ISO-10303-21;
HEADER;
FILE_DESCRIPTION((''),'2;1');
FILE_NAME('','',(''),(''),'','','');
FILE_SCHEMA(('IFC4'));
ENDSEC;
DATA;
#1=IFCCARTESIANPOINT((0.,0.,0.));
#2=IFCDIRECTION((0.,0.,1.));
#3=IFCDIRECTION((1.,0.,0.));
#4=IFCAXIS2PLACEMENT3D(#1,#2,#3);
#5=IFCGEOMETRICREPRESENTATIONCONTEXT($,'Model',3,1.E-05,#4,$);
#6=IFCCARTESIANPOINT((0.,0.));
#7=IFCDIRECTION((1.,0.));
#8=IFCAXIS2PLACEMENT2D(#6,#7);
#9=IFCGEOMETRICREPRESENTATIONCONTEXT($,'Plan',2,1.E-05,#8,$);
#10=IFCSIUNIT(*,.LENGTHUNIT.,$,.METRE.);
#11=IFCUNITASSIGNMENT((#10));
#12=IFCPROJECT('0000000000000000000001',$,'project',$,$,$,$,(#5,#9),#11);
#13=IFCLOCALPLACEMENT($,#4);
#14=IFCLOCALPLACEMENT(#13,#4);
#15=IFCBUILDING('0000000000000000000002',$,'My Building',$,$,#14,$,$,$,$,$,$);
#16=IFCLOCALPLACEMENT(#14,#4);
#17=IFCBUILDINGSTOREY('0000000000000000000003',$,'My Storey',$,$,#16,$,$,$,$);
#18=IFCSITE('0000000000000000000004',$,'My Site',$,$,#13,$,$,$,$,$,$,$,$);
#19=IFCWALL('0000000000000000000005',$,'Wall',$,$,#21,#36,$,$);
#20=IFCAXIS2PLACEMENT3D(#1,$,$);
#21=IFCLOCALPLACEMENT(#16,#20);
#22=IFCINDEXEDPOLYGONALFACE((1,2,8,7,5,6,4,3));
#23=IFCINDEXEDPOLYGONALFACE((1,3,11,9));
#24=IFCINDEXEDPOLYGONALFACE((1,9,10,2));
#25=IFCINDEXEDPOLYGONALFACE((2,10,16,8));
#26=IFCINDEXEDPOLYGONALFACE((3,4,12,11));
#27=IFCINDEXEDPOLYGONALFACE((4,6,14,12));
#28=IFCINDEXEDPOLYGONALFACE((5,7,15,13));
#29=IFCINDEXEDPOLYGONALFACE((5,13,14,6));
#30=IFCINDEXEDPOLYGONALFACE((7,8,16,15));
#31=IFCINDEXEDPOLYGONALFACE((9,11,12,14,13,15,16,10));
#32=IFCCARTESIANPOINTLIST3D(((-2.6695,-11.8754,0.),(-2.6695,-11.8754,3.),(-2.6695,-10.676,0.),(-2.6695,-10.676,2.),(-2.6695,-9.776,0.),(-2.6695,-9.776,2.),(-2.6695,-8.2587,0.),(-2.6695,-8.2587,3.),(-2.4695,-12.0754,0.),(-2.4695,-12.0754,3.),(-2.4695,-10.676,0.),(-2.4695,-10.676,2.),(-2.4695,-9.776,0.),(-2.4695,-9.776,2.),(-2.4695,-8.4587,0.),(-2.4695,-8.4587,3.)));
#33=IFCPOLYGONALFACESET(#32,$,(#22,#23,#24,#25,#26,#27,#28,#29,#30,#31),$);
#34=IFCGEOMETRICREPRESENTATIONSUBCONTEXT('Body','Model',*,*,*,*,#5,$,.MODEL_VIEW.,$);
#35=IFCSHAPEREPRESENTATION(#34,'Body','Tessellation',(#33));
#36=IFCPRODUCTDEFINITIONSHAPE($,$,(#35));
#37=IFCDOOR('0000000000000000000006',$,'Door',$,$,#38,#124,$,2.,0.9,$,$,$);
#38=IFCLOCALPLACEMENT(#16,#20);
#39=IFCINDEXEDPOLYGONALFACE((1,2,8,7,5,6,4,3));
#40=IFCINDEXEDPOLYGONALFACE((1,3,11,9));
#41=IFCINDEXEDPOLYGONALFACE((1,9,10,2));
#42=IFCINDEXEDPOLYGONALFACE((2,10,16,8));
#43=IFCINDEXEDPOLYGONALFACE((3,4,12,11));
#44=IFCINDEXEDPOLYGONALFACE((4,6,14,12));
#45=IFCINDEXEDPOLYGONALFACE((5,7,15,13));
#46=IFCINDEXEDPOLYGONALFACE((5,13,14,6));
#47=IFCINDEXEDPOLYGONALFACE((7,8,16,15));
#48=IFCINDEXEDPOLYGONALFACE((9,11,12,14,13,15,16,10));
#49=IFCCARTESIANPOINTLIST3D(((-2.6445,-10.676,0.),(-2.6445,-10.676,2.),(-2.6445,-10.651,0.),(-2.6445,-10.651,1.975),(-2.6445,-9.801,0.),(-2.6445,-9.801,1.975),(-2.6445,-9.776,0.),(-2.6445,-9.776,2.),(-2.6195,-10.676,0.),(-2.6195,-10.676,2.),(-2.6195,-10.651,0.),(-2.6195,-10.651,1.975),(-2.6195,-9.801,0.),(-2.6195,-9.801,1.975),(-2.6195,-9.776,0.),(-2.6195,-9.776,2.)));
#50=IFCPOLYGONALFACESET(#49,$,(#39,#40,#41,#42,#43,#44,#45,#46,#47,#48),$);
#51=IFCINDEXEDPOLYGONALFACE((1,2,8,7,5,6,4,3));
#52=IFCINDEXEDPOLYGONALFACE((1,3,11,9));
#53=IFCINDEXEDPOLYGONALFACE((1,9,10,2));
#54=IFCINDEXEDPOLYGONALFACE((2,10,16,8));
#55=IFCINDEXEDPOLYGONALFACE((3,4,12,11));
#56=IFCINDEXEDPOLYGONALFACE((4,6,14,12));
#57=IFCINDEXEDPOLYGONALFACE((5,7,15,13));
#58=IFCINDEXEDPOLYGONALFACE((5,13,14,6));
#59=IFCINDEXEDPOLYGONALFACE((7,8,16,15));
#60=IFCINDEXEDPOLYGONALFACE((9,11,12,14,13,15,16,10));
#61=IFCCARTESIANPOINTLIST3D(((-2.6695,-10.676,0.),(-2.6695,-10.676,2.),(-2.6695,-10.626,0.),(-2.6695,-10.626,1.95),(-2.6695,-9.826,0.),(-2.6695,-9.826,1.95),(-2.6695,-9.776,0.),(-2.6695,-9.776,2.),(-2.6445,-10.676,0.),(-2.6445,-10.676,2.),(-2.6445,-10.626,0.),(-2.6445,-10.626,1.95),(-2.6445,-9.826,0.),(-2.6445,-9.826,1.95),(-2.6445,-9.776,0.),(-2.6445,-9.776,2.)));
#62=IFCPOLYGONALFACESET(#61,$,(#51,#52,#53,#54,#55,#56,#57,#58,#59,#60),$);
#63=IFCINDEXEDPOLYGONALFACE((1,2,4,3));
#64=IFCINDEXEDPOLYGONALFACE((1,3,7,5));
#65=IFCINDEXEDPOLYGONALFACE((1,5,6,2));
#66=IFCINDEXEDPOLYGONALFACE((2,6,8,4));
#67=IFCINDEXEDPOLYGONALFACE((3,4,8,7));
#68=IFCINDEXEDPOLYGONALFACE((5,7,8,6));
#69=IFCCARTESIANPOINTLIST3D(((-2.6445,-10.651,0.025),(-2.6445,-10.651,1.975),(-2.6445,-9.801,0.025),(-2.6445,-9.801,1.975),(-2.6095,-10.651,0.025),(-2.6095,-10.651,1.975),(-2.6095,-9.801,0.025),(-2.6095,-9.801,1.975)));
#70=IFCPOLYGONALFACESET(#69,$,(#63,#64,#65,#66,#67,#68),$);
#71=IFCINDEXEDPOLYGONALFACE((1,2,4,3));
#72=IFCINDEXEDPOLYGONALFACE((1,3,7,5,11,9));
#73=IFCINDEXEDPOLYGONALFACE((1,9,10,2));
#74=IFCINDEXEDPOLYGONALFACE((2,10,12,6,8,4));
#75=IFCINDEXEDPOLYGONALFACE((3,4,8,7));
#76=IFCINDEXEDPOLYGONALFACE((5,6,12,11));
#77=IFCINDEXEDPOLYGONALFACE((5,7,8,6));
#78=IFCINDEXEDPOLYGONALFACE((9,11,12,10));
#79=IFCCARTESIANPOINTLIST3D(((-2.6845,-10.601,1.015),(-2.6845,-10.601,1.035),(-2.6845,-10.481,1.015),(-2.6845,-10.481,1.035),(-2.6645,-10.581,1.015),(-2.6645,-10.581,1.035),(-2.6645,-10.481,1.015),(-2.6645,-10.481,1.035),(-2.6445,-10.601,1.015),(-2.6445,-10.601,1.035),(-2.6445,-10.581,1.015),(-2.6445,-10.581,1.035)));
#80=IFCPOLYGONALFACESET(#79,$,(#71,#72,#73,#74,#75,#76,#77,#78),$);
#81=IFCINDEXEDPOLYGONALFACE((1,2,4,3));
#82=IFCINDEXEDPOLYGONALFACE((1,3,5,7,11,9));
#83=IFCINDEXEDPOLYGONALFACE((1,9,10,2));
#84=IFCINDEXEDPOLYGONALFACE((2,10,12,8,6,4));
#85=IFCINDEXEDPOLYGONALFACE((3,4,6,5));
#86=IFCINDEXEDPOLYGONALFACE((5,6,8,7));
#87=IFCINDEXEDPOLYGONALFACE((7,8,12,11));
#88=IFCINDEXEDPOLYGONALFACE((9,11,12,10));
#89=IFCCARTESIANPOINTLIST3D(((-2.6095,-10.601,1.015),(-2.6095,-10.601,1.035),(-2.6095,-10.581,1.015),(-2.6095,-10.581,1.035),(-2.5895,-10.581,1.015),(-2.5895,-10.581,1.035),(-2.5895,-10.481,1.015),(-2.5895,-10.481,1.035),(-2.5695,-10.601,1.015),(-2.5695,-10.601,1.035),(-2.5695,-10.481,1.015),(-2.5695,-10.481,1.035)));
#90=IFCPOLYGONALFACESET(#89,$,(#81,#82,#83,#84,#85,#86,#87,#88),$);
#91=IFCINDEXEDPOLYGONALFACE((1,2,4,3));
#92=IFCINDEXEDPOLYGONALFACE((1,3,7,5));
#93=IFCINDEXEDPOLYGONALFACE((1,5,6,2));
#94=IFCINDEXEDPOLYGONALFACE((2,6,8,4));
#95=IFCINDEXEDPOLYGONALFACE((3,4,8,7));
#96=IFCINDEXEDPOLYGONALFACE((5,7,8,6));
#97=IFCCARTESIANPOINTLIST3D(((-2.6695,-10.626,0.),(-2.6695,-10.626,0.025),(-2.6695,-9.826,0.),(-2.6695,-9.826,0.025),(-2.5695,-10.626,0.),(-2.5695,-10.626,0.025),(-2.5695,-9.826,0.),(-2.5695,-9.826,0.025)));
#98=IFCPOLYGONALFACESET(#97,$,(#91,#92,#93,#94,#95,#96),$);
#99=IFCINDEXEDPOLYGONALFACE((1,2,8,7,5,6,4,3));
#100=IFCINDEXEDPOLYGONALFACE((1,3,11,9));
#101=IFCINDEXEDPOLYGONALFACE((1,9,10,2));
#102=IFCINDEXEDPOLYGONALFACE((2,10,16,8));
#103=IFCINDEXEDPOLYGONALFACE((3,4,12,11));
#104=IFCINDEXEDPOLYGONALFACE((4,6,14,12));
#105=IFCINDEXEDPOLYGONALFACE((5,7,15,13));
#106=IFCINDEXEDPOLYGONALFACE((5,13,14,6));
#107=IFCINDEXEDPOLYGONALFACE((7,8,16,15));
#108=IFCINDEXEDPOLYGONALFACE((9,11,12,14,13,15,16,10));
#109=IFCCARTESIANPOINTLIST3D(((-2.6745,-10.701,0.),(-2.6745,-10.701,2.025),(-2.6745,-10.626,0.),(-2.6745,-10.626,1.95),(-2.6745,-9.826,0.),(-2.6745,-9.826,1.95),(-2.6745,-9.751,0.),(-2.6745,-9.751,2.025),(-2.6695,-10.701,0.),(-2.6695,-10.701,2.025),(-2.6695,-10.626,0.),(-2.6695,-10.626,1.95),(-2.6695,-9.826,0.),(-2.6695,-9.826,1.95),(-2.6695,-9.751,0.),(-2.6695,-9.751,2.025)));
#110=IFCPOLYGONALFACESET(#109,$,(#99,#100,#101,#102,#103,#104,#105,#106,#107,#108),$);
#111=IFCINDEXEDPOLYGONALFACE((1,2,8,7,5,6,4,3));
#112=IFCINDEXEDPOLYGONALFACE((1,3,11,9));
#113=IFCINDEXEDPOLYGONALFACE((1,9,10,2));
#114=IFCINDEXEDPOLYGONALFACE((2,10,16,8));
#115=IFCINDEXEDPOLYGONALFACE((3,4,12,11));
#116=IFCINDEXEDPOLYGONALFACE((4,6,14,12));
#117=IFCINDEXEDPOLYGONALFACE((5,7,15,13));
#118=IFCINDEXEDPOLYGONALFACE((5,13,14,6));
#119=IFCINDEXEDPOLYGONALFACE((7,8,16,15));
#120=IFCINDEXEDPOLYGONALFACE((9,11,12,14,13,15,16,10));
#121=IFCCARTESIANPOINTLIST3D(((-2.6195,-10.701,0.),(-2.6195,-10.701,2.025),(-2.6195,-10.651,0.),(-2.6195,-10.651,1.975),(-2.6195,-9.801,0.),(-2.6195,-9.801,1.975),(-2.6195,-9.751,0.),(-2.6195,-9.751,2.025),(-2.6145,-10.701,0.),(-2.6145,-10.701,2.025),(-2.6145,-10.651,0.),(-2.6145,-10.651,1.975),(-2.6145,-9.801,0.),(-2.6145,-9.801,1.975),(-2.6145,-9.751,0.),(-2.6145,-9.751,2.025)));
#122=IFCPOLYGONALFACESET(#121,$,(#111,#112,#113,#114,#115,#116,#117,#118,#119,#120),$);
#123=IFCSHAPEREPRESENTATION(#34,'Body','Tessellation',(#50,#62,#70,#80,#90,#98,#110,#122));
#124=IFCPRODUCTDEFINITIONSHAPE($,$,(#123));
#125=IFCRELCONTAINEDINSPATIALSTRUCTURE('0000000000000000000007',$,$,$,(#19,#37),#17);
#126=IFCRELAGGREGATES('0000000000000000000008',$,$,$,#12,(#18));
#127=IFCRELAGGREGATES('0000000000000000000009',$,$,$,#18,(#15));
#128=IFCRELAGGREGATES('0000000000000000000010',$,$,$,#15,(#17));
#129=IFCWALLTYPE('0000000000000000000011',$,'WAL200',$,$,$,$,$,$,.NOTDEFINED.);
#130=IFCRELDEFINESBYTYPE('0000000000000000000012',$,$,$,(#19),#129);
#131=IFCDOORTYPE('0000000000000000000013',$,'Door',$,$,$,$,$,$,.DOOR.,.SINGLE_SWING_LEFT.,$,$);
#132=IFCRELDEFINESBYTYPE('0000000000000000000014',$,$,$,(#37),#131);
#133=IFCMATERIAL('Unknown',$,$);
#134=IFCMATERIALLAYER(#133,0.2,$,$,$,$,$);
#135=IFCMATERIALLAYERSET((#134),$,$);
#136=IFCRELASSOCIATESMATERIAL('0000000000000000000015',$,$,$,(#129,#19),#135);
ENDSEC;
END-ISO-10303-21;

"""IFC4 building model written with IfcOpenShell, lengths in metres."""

from ifc_helpers import new_model, entity, si_unit, frame, origin_with_axes, origin_2d_with_axis, place, context, subcontext, project, spatial, line, indexed_curve, outline, extrude, shape, source, transform, mapped, material, layer, layer_set, layer_usage, type_object, type_shapes, element, fill, save


model = new_model("IFC4")

# Units and contexts
model_context = context("Model", 3, precision=1e-05, world=origin_with_axes())
plan_context = context("Plan", 2, precision=1e-05, world=origin_2d_with_axis())
body_context_1 = subcontext(model_context, "Body", "Model", "MODEL_VIEW")
body_context_2 = subcontext(plan_context, "Body", "Plan", "PLAN_VIEW")
ifc_project = project(units=[si_unit("LENGTHUNIT", "METRE")], contexts=[model_context, plan_context])

# Site, building, storey
site_placement = place(None, origin_with_axes())
site = spatial("IfcSite", under=ifc_project, at=site_placement, Name="My Site")
building_placement = place(site_placement, origin_with_axes())
building = spatial("IfcBuilding", under=site, at=building_placement, Name="My Building")
storey_placement = place(building_placement, origin_with_axes())
storey = spatial("IfcBuildingStorey", under=building, at=storey_placement, Name="My Storey")

# Shared definitions
ifc_material = material(Name="Unknown")

# Shared definitions
ifc_layer_1 = layer(ifc_material, 0.2)
ifc_layer_set_1 = layer_set([ifc_layer_1])
wall_type_1 = type_object("IfcWallType", Name="WAL200", PredefinedType="NOTDEFINED", material=ifc_layer_set_1)

# Wall, opening, door
ifc_layer_usage_1 = layer_usage(ifc_layer_set_1, "AXIS2", "POSITIVE", 0.0)
wall_1_placement = place(storey_placement, frame((-2.4695, -12.0754, 0.0), z_axis=(0.0, 0.0, 1.0), x_axis=(0.0, 1.0, 0.0)))
wall_1 = element("IfcWall", 1, at=wall_1_placement, inside=storey, type_object=wall_type_1, material=ifc_layer_usage_1, Name="Wall", context=body_context_1, shape_type="SweptSolid", body=[
    extrude(outline(indexed_curve([(0.0, 0.0), (0.2, 0.2), (3.8168, 0.2), (3.6168, 0.0)], segments=[line(1, 2, 3, 4, 1)])), origin_with_axes(), (0.0, 0.0, 1.0), 3.0),
])
shared_shape_1 = source(origin_with_axes(), body_context_1, "Body", "SweptSolid", [
    extrude(outline(indexed_curve([(0.0, 0.0), (0.9, 0.0), (0.9, 2.0), (0.0, 2.0)], segments=[line(1, 2, 3, 4, 1)])), frame((0.0, -0.6, 0.0), z_axis=(0.0, -1.0, 0.0), x_axis=(1.0, 0.0, 0.0)), (0.0, 0.0, -1.0), 1.2),
])
opening_1_placement = place(wall_1_placement, frame((2.2995, 0.2, 0.0), z_axis=(0.0, 0.0, 1.0), x_axis=(-1.0, 0.0, 0.0)))
opening_1 = element("IfcOpeningElement", 2, at=opening_1_placement, cuts=wall_1, PredefinedType="OPENING", context=body_context_1, shape_type="MappedRepresentation", body=[
    mapped(shared_shape_1, transform((0.0, 0.0, 0.0), x_axis=(1.0, 0.0, 0.0), y_axis=(0.0, 1.0, 0.0), z_axis=(0.0, 0.0, 1.0), scale=1.0)),
])
door_type = type_object("IfcDoorType", Name="Door", OperationType="SINGLE_SWING_LEFT", PredefinedType="DOOR")
shared_shape_2 = source(origin_with_axes(), body_context_1, "Body", "SweptSolid", [
    extrude(outline(indexed_curve([(0.0, 0.0), (0.0, 2.0), (0.9, 2.0), (0.9, 0.0), (0.875, 0.0), (0.875, 1.975), (0.025, 1.975), (0.025, 0.0)], segments=[line(1, 2, 3, 4, 5, 6, 7, 8, 1)])), frame((0.0, 0.025, 0.0), z_axis=(0.0, -1.0, 0.0), x_axis=(1.0, 0.0, 0.0)), (0.0, 0.0, -1.0), 0.025),
    extrude(outline(indexed_curve([(0.0, 0.0), (0.0, 2.0), (0.9, 2.0), (0.9, 0.0), (0.85, 0.0), (0.85, 1.95), (0.05, 1.95), (0.05, 0.0)], segments=[line(1, 2, 3, 4, 5, 6, 7, 8, 1)])), frame((0.0, 0.0, 0.0), z_axis=(0.0, -1.0, 0.0), x_axis=(1.0, 0.0, 0.0)), (0.0, 0.0, -1.0), 0.025),
    extrude(outline(indexed_curve([(0.0, 0.0), (0.85, 0.0), (0.85, 0.035), (0.0, 0.035)], segments=[line(1, 2, 3, 4, 1)])), frame((0.025, 0.025, 0.025), z_axis=(0.0, 0.0, 1.0), x_axis=(1.0, 0.0, 0.0)), (0.0, 0.0, 1.0), 1.95),
    extrude(outline(indexed_curve([(0.0, 0.0), (0.0, -0.04), (-0.12, -0.04), (-0.12, -0.02), (-0.02, -0.02), (-0.02, 0.0)], segments=[line(1, 2, 3, 4, 5, 6, 1)])), frame((0.825, 0.025, 1.015), z_axis=(0.0, 0.0, 1.0), x_axis=(1.0, 0.0, 0.0)), (0.0, 0.0, 1.0), 0.02),
    extrude(outline(indexed_curve([(0.0, 0.0), (0.0, 0.04), (-0.12, 0.04), (-0.12, 0.02), (-0.02, 0.02), (-0.02, 0.0)], segments=[line(1, 2, 3, 4, 5, 6, 1)])), frame((0.825, 0.06, 1.015), z_axis=(0.0, 0.0, 1.0), x_axis=(1.0, 0.0, 0.0)), (0.0, 0.0, 1.0), 0.02),
    extrude(outline(indexed_curve([(0.0, 0.0), (0.8, 0.0), (0.8, 0.1), (0.0, 0.1)], segments=[line(1, 2, 3, 4, 1)])), frame((0.05, 0.0, 0.0), z_axis=(0.0, 0.0, 1.0), x_axis=(1.0, 0.0, 0.0)), (0.0, 0.0, 1.0), 0.025),
    extrude(outline(indexed_curve([(0.0, 0.0), (0.0, 2.025), (0.95, 2.025), (0.95, 0.0), (0.875, 0.0), (0.875, 1.95), (0.075, 1.95), (0.075, 0.0)], segments=[line(1, 2, 3, 4, 5, 6, 7, 8, 1)])), frame((-0.025, -0.005, 0.0), z_axis=(0.0, -1.0, 0.0), x_axis=(1.0, 0.0, 0.0)), (0.0, 0.0, -1.0), 0.005),
    extrude(outline(indexed_curve([(0.0, 0.0), (0.0, 2.025), (0.95, 2.025), (0.95, 0.0), (0.9, 0.0), (0.9, 1.975), (0.05, 1.975), (0.05, 0.0)], segments=[line(1, 2, 3, 4, 5, 6, 7, 8, 1)])), frame((-0.025, 0.05, 0.0), z_axis=(0.0, -1.0, 0.0), x_axis=(1.0, 0.0, 0.0)), (0.0, 0.0, -1.0), 0.005),
])
shared_shape_3 = source(origin_with_axes(), body_context_2, "Body", "Curve2D", [
    entity("IfcIndexedPolyCurve", entity("IfcCartesianPointList2D", [[0.0, 0.0], [0.0, 0.05], [0.025, 0.05], [0.025, 0.025], [0.05, 0.025], [0.05, 0.0]]), [entity("IfcLineIndex", [1, 2, 3, 4, 5, 6, 1])]),
    entity("IfcIndexedPolyCurve", entity("IfcCartesianPointList2D", [[0.9, 0.0], [0.9, 0.05], [0.875, 0.05], [0.875, 0.025], [0.85, 0.025], [0.85, 0.0]]), [entity("IfcLineIndex", [1, 2, 3, 4, 5, 6, 1])]),
    entity("IfcTrimmedCurve", entity("IfcEllipse", entity("IfcAxis2Placement2D", entity("IfcCartesianPoint", [0.06, 0.05]), entity("IfcDirection", [1.0, 0.0])), 0.815, 0.85), [entity("IfcCartesianPoint", [0.875, 0.05])], [entity("IfcCartesianPoint", [0.06, 0.9])], True, "CARTESIAN"),
    entity("IfcIndexedPolyCurve", entity("IfcCartesianPointList2D", [[0.025, 0.05], [0.06, 0.05], [0.06, 0.9], [0.025, 0.9]]), [entity("IfcLineIndex", [1, 2, 3, 4, 1])]),
])
type_shapes(door_type, [shared_shape_2, shared_shape_3])
door_1_placement = place(opening_1_placement, origin_with_axes())
door_1 = element("IfcDoor", 3, at=door_1_placement, inside=storey, type_object=door_type, Name="Door", OverallHeight=2.0, OverallWidth=0.9, shapes=[
    shape(body_context_1, "Body", "MappedRepresentation", [mapped(shared_shape_2, transform((0.0, 0.0, 0.0), x_axis=(1.0, 0.0, 0.0), y_axis=(0.0, 1.0, 0.0), z_axis=(0.0, 0.0, 1.0), scale=1.0))]),
    shape(body_context_2, "Body", "MappedRepresentation", [mapped(shared_shape_3, transform((0.0, 0.0, 0.0), x_axis=(1.0, 0.0, 0.0), y_axis=(0.0, 1.0, 0.0), z_axis=(0.0, 0.0, 1.0), scale=1.0))]),
])
fill(opening_1, door_1)

save(model, "model.ifc")
